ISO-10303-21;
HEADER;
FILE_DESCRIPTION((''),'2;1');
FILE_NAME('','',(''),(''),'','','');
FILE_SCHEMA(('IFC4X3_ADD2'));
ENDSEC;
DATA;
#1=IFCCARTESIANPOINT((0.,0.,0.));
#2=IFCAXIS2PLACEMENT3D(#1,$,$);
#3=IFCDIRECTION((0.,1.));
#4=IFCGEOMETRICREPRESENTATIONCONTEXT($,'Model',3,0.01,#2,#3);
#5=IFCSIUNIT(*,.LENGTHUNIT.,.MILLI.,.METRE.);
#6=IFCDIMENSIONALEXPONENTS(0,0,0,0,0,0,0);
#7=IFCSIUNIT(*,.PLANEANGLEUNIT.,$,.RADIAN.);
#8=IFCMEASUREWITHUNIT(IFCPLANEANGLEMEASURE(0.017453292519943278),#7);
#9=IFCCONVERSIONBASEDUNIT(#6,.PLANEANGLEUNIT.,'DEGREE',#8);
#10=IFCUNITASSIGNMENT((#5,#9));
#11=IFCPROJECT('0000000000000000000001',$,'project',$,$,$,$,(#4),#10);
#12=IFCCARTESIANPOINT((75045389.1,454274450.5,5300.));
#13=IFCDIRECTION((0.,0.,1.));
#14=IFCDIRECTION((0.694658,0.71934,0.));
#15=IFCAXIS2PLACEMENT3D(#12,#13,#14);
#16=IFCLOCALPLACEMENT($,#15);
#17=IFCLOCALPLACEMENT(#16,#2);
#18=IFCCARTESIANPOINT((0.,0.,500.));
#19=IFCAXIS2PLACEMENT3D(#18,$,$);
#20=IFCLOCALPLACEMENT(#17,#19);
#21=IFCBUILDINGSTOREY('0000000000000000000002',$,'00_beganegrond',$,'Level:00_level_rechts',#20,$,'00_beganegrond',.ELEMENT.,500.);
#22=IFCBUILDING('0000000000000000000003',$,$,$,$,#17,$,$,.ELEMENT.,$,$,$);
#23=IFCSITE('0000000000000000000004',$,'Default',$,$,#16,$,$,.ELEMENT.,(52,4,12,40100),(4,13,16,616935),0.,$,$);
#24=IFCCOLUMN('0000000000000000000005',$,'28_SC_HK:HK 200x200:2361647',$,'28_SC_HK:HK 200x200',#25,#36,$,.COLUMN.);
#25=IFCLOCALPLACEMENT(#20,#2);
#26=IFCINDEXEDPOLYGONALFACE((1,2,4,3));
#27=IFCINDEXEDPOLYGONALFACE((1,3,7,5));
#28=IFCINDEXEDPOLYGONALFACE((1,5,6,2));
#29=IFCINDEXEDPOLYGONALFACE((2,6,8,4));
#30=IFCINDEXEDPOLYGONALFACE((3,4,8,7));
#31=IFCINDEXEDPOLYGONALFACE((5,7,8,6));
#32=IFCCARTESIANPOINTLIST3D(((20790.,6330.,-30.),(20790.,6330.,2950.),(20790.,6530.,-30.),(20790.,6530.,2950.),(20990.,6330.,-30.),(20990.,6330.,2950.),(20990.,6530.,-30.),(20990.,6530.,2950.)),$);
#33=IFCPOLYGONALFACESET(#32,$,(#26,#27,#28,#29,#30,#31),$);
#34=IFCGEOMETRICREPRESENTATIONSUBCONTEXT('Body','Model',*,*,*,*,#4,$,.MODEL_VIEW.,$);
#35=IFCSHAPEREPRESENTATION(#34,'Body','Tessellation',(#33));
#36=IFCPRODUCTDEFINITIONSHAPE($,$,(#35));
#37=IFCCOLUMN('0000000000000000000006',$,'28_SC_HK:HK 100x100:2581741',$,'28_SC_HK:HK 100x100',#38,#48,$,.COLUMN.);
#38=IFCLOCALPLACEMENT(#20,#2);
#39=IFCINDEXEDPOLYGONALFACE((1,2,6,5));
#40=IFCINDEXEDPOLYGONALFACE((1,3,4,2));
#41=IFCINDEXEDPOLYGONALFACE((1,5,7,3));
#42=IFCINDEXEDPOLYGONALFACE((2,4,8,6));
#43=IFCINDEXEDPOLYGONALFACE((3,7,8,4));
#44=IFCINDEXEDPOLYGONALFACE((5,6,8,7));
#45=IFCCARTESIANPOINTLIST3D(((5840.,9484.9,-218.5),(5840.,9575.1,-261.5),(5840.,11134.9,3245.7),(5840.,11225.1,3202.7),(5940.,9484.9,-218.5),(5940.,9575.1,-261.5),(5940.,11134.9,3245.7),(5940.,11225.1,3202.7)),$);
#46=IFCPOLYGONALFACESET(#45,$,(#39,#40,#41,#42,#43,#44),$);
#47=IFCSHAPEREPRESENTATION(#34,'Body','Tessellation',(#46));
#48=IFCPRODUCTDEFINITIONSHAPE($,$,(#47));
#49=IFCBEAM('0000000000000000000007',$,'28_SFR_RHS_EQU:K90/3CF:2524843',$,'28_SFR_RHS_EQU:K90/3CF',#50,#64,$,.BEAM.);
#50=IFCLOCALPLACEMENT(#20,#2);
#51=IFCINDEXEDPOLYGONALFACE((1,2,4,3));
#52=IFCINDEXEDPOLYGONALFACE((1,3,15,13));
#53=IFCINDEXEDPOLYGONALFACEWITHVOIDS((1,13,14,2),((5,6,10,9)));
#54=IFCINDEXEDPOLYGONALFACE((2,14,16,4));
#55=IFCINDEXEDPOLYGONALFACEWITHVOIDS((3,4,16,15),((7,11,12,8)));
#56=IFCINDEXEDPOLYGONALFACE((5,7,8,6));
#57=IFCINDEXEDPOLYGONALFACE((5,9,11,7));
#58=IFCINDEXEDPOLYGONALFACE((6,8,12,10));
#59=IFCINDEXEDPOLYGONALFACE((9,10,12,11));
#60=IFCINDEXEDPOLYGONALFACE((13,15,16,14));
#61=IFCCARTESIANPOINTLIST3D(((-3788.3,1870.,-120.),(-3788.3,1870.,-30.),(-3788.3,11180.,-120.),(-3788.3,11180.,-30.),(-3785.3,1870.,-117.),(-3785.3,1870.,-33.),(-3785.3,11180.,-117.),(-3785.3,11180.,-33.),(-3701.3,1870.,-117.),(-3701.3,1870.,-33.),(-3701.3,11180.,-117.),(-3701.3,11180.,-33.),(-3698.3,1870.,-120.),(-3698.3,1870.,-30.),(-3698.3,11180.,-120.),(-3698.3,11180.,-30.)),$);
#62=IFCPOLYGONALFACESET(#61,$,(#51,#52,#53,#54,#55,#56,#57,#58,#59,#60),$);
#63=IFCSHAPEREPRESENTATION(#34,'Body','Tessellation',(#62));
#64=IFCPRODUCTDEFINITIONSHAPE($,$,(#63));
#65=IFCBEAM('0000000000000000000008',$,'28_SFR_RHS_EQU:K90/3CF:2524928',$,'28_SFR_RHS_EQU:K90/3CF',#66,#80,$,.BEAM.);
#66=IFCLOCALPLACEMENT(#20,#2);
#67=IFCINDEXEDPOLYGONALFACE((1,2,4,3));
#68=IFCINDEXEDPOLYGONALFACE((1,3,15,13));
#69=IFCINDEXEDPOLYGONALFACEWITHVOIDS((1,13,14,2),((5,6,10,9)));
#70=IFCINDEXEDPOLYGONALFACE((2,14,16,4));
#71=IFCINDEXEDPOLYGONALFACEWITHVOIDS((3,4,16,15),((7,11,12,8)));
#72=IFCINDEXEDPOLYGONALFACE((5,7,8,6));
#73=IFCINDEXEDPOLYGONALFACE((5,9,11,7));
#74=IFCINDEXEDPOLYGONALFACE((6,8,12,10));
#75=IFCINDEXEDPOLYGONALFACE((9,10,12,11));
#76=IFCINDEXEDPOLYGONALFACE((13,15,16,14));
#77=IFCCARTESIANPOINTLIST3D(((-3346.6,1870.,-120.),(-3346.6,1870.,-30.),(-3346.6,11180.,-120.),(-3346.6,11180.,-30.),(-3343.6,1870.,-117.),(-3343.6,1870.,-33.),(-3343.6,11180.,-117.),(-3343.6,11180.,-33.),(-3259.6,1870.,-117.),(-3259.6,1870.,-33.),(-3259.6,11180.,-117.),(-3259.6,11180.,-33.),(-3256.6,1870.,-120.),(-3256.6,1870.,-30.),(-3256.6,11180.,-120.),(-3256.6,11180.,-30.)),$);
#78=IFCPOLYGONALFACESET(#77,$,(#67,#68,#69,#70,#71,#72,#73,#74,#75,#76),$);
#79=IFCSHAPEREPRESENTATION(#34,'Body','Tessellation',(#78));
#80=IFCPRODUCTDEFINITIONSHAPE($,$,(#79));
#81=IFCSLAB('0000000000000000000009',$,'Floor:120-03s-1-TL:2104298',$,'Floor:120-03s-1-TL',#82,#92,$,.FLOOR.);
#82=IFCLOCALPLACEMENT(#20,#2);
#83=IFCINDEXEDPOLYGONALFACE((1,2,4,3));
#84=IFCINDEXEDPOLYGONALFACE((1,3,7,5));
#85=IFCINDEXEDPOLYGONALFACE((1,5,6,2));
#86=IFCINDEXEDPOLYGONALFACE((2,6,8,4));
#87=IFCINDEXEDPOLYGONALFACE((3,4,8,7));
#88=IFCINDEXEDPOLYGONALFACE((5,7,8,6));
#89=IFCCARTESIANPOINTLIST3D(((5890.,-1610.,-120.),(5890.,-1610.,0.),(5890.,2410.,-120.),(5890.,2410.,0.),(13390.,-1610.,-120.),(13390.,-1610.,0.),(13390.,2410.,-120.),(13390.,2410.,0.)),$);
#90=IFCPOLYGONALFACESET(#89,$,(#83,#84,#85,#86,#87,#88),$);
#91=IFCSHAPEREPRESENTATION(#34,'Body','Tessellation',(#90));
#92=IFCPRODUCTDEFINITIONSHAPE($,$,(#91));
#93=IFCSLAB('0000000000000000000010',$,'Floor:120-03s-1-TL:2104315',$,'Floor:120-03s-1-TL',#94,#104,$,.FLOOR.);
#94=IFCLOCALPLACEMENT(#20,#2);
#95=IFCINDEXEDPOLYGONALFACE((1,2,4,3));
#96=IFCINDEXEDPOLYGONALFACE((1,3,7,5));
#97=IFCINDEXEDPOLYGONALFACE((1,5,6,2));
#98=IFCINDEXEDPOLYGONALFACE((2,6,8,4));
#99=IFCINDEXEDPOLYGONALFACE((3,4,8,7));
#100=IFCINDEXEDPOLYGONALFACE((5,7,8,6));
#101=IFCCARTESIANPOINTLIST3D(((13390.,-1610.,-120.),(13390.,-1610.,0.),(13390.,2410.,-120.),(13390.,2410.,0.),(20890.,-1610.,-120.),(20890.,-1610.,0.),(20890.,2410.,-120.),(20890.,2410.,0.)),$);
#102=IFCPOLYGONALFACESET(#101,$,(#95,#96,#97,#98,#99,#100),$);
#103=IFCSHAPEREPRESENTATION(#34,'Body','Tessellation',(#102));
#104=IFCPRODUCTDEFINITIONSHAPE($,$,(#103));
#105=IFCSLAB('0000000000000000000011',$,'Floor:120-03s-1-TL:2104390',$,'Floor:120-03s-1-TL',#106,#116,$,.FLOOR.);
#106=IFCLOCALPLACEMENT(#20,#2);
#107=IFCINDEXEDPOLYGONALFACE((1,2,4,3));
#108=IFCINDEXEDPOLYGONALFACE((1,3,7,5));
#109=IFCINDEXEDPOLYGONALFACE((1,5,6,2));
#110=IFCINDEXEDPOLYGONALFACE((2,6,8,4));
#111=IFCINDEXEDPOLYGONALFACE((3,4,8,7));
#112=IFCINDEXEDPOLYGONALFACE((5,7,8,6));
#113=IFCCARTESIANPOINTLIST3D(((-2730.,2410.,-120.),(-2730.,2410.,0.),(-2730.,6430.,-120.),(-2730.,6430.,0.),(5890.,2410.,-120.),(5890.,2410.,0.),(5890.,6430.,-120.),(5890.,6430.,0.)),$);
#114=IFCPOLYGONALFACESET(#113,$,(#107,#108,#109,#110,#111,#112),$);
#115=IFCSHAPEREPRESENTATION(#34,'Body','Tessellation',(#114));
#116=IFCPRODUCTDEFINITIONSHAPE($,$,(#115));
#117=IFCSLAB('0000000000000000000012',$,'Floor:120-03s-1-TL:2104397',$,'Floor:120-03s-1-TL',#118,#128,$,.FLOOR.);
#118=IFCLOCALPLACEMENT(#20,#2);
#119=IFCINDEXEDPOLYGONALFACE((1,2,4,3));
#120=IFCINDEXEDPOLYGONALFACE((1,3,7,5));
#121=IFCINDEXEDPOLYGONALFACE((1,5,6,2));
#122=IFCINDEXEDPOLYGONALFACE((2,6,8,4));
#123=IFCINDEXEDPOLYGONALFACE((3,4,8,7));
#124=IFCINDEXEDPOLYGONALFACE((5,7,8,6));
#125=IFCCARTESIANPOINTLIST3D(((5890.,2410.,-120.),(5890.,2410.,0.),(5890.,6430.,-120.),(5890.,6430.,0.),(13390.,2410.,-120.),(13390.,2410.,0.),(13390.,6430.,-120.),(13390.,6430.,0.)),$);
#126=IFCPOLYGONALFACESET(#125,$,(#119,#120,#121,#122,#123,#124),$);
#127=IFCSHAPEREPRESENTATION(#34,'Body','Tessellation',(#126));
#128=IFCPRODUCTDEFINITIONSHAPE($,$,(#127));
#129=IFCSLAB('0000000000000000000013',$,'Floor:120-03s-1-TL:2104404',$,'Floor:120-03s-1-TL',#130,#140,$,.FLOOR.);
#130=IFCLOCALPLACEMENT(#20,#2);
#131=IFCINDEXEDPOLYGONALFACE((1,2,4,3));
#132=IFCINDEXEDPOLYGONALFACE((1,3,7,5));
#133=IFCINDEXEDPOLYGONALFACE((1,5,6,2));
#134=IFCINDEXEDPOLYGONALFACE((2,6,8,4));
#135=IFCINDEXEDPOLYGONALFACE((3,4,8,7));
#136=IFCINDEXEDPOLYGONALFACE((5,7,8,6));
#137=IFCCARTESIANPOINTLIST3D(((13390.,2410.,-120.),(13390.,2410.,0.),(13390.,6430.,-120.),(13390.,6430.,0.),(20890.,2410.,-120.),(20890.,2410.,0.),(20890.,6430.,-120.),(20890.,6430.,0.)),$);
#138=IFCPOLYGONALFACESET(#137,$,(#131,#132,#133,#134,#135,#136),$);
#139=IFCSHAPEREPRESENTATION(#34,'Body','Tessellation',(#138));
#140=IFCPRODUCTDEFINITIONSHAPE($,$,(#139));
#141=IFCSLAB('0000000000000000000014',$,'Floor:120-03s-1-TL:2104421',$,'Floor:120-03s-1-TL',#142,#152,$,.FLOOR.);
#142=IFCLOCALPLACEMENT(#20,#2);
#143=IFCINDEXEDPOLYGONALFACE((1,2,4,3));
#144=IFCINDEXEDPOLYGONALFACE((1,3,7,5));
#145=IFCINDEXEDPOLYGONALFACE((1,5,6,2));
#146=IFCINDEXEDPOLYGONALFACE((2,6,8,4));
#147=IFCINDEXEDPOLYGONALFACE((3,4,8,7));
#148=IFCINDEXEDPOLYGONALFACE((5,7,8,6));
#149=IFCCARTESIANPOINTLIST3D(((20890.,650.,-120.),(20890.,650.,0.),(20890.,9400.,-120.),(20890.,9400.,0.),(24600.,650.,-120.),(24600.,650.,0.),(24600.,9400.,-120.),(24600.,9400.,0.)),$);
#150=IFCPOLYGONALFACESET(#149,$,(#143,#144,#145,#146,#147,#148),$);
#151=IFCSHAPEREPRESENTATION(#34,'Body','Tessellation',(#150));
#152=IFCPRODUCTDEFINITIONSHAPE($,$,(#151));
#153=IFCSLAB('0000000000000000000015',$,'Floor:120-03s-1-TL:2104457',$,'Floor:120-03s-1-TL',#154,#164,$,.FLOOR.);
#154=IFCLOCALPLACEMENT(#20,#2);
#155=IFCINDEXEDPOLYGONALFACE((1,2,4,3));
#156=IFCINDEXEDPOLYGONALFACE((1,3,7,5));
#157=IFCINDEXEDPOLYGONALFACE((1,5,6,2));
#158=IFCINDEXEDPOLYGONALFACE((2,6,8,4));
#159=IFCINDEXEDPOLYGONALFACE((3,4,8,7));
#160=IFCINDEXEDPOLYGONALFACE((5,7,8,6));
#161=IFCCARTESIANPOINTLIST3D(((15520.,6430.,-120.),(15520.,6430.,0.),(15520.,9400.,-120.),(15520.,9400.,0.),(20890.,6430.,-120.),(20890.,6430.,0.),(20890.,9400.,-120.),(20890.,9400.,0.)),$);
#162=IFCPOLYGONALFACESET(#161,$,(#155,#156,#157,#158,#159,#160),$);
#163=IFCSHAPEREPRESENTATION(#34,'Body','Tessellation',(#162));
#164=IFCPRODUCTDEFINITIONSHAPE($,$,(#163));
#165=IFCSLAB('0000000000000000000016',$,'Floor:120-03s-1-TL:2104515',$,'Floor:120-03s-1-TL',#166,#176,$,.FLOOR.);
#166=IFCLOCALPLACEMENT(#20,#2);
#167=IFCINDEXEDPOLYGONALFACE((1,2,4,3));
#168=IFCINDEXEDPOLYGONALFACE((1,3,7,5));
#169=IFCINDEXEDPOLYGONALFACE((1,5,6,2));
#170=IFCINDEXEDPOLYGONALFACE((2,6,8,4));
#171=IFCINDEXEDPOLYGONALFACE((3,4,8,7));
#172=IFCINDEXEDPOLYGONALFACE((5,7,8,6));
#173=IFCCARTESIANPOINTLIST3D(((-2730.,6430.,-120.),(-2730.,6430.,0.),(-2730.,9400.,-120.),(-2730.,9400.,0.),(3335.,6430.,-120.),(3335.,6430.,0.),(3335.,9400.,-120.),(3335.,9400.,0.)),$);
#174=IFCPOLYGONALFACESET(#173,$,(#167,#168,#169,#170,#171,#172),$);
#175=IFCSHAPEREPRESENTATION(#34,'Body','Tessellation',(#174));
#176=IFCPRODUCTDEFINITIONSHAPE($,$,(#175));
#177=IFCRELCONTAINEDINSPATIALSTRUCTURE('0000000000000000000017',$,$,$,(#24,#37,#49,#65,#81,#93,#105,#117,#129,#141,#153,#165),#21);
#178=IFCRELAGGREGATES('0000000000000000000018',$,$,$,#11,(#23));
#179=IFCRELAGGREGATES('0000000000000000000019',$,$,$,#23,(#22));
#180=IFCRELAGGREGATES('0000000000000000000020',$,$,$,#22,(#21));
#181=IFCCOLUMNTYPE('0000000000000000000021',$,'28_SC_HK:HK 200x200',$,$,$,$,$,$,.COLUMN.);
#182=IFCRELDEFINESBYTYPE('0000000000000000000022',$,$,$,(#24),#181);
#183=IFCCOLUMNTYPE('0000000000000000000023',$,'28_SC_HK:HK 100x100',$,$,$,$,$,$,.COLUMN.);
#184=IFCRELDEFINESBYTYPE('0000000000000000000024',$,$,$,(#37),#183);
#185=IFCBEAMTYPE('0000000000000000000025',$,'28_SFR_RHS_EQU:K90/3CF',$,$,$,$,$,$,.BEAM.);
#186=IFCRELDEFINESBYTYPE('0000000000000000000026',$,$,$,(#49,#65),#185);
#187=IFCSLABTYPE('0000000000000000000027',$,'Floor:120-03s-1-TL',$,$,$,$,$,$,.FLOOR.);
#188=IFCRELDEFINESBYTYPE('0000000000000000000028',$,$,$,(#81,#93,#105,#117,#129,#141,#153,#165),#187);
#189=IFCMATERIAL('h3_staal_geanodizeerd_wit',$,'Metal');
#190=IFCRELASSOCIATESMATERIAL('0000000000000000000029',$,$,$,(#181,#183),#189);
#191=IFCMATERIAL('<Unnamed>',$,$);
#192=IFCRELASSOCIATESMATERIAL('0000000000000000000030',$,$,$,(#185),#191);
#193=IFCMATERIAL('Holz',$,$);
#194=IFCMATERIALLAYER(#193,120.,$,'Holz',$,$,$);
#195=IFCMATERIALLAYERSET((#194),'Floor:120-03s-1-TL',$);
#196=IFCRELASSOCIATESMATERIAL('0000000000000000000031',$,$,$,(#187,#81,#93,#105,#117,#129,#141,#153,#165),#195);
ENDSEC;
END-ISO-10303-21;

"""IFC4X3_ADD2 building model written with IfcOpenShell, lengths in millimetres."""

from ifc_helpers import new_model, entity, si_unit, converted_unit, direction, frame, frame_2d, origin, origin_2d_with_axis, place, context, subcontext, project, spatial, polyline, rectangle, outline, extrude, source, transform, mapped, material, layer, layer_set, layer_usage, material_profile, profile_set, type_object, type_shapes, element, save


model = new_model("IFC4X3_ADD2")

# Units and contexts
model_context = context("Model", 3, precision=0.01, world=origin(), true_north=direction((0.0, 1.0)))
body_context = subcontext(model_context, "Body", "Model", "MODEL_VIEW")
ifc_project = project(units=[si_unit("LENGTHUNIT", "METRE", prefix="MILLI"), converted_unit("PLANEANGLEUNIT", "DEGREE", entity("IfcPlaneAngleMeasure", 0.017453292519943278), si_unit("PLANEANGLEUNIT", "RADIAN"), dimensions=[0, 0, 0, 0, 0, 0, 0])], contexts=[model_context])

# Site, building, storey
site_placement = place(None, frame((75045389.1, 454274450.5, 5300.0), z_axis=(0.0, 0.0, 1.0), x_axis=(0.694658, 0.71934, 0.0)))
site = spatial("IfcSite", under=ifc_project, at=site_placement, Name="Default", CompositionType="ELEMENT", RefLatitude=(52, 4, 12, 40100), RefLongitude=(4, 13, 16, 616935), RefElevation=0.0)
building_placement = place(site_placement, origin())
building = spatial("IfcBuilding", under=site, at=building_placement, CompositionType="ELEMENT")
storey_placement = place(building_placement, frame((0.0, 0.0, 500.0)))
storey = spatial("IfcBuildingStorey", under=building, at=storey_placement, Name="00_beganegrond", ObjectType="Level:00_level_rechts", LongName="00_beganegrond", CompositionType="ELEMENT", Elevation=500.0)

# Columns
ifc_material_1 = material(Name="h3_staal_geanodizeerd_wit", Category="Metal")
ifc_material_profile_1 = material_profile(ifc_material_1, rectangle(XDim=200.0, YDim=200.0, at=origin_2d_with_axis()), Name="HK 200x200")
ifc_profile_set_1 = profile_set([ifc_material_profile_1], Name="HK 200x200")
column_type_1 = type_object("IfcColumnType", Name="28_SC_HK:HK 200x200", PredefinedType="COLUMN", material=ifc_profile_set_1)
shared_shape_1 = source(origin(), body_context, "Body", "SweptSolid", [
    extrude(rectangle(XDim=200.0, YDim=200.0, at=origin_2d_with_axis()), frame((20890.0, 6430.0, 470.0), z_axis=(0.0, 0.0, 1.0), x_axis=(-1.0, 0.0, 0.0)), (0.0, 0.0, 1.0), 2980.0),
])
type_shapes(column_type_1, [shared_shape_1])
column_1_placement = place(storey_placement, frame((0.0, 0.0, -500.0)))
element("IfcColumn", 1, at=column_1_placement, inside=storey, type_object=column_type_1, Name="28_SC_HK:HK 200x200:2361647", ObjectType="28_SC_HK:HK 200x200", PredefinedType="COLUMN", context=body_context, shape_type="MappedRepresentation", body=[
    mapped(shared_shape_1, transform((0.0, 0.0, 0.0), scale=1.0)),
])
ifc_material_profile_2 = material_profile(ifc_material_1, rectangle(XDim=100.0, YDim=100.0, at=frame_2d((0.0, 0.0), x_axis=(1.0, 0.0))), Name="HK 100x100")
ifc_profile_set_2 = profile_set([ifc_material_profile_2], Name="HK 100x100")
column_type_2 = type_object("IfcColumnType", Name="28_SC_HK:HK 100x100", PredefinedType="COLUMN", material=ifc_profile_set_2)
shared_shape_2 = source(origin(), body_context, "Body", "SweptSolid", [
    extrude(rectangle(XDim=100.0, YDim=100.0, at=frame_2d((0.0, 0.0), x_axis=(1.0, 0.0))), frame((5890.0, 9530.0, 260.0), z_axis=(0.0, 0.430013, 0.902823), x_axis=(0.0, -0.902823, 0.430013)), (0.0, 0.0, 1.0), 3837.1),
])
type_shapes(column_type_2, [shared_shape_2])
column_2_placement = place(storey_placement, frame((0.0, 0.0, -500.0)))
element("IfcColumn", 2, at=column_2_placement, inside=storey, type_object=column_type_2, Name="28_SC_HK:HK 100x100:2581741", ObjectType="28_SC_HK:HK 100x100", PredefinedType="COLUMN", context=body_context, shape_type="MappedRepresentation", body=[
    mapped(shared_shape_2, transform((0.0, 0.0, 0.0), scale=1.0)),
])

# Beams
ifc_material_2 = material(Name="<Unnamed>")
ifc_material_profile_3 = material_profile(ifc_material_2, outline(polyline([(-45.0, -45.0), (45.0, -45.0), (45.0, 45.0), (-45.0, 45.0), (-45.0, -45.0)]), holes=[polyline([(42.0, -42.0), (-42.0, -42.0), (-42.0, 42.0), (42.0, 42.0), (42.0, -42.0)])]), Name="K90/3CF")
ifc_profile_set_3 = profile_set([ifc_material_profile_3], Name="K90/3CF")
beam_type = type_object("IfcBeamType", Name="28_SFR_RHS_EQU:K90/3CF", PredefinedType="BEAM", material=ifc_profile_set_3)
shared_shape_3 = source(origin(), body_context, "Body", "SweptSolid", [
    extrude(outline(polyline([(-45.0, -45.0), (45.0, -45.0), (45.0, 45.0), (-45.0, 45.0), (-45.0, -45.0)]), holes=[polyline([(42.0, -42.0), (-42.0, -42.0), (-42.0, 42.0), (42.0, 42.0), (42.0, -42.0)])]), frame((-4655.0, 0.0, 0.0), z_axis=(1.0, 0.0, 0.0), x_axis=(0.0, -1.0, 0.0)), (0.0, 0.0, 1.0), 9310.0),
])
type_shapes(beam_type, [shared_shape_3])
for number, where, z_axis, x_axis, name in (
    (3, (-3743.3, 6525.0, -75.0), (0.0, 0.0, 1.0), (0.0, 1.0, 0.0), "28_SFR_RHS_EQU:K90/3CF:2524843"),
    (4, (-3301.6, 6525.0, -75.0), (0.0, 0.0, 1.0), (0.0, 1.0, 0.0), "28_SFR_RHS_EQU:K90/3CF:2524928"),
):
    element("IfcBeam", number, at=place(storey_placement, frame(where, z_axis=z_axis, x_axis=x_axis)), inside=storey, type_object=beam_type, Name=name, ObjectType="28_SFR_RHS_EQU:K90/3CF", PredefinedType="BEAM", context=body_context, shape_type="MappedRepresentation", body=[
        mapped(shared_shape_3, transform((0.0, 0.0, 0.0), scale=1.0)),
    ])

# Slabs
ifc_material_3 = material(Name="Holz")
ifc_layer_1 = layer(ifc_material_3, 120.0, Name="Holz")
ifc_layer_set_1 = layer_set([ifc_layer_1], Name="Floor:120-03s-1-TL")
slab_type_1 = type_object("IfcSlabType", Name="Floor:120-03s-1-TL", PredefinedType="FLOOR", material=ifc_layer_set_1)
ifc_layer_usage_1 = layer_usage(ifc_layer_set_1, "AXIS3", "POSITIVE", 0.0)
slab_1_placement = place(storey_placement, origin())
element("IfcSlab", 5, at=slab_1_placement, inside=storey, type_object=slab_type_1, material=ifc_layer_usage_1, Name="Floor:120-03s-1-TL:2104298", ObjectType="Floor:120-03s-1-TL", PredefinedType="FLOOR", context=body_context, shape_type="SweptSolid", body=[
    extrude(rectangle(XDim=4020.0, YDim=7500.0, at=origin_2d_with_axis()), frame((9640.0, 400.0, 0.0), z_axis=(0.0, 0.0, -1.0), x_axis=(0.0, 1.0, 0.0)), (0.0, 0.0, 1.0), 120.0),
])
ifc_layer_usage_2 = layer_usage(ifc_layer_set_1, "AXIS3", "POSITIVE", 0.0)
slab_2_placement = place(storey_placement, origin())
element("IfcSlab", 6, at=slab_2_placement, inside=storey, type_object=slab_type_1, material=ifc_layer_usage_2, Name="Floor:120-03s-1-TL:2104315", ObjectType="Floor:120-03s-1-TL", PredefinedType="FLOOR", context=body_context, shape_type="SweptSolid", body=[
    extrude(rectangle(XDim=4020.0, YDim=7500.0, at=origin_2d_with_axis()), frame((17140.0, 400.0, 0.0), z_axis=(0.0, 0.0, -1.0), x_axis=(0.0, 1.0, 0.0)), (0.0, 0.0, 1.0), 120.0),
])
ifc_layer_usage_3 = layer_usage(ifc_layer_set_1, "AXIS3", "POSITIVE", 0.0)
slab_3_placement = place(storey_placement, origin())
element("IfcSlab", 7, at=slab_3_placement, inside=storey, type_object=slab_type_1, material=ifc_layer_usage_3, Name="Floor:120-03s-1-TL:2104390", ObjectType="Floor:120-03s-1-TL", PredefinedType="FLOOR", context=body_context, shape_type="SweptSolid", body=[
    extrude(rectangle(XDim=4020.0, YDim=8620.0, at=frame_2d((0.0, 0.0), x_axis=(1.0, 0.0))), frame((1580.0, 4420.0, 0.0), z_axis=(0.0, 0.0, -1.0), x_axis=(0.0, 1.0, 0.0)), (0.0, 0.0, 1.0), 120.0),
])
ifc_layer_usage_4 = layer_usage(ifc_layer_set_1, "AXIS3", "POSITIVE", 0.0)
slab_4_placement = place(storey_placement, origin())
element("IfcSlab", 8, at=slab_4_placement, inside=storey, type_object=slab_type_1, material=ifc_layer_usage_4, Name="Floor:120-03s-1-TL:2104397", ObjectType="Floor:120-03s-1-TL", PredefinedType="FLOOR", context=body_context, shape_type="SweptSolid", body=[
    extrude(rectangle(XDim=4020.0, YDim=7500.0, at=origin_2d_with_axis()), frame((9640.0, 4420.0, 0.0), z_axis=(0.0, 0.0, -1.0), x_axis=(0.0, 1.0, 0.0)), (0.0, 0.0, 1.0), 120.0),
])
ifc_layer_usage_5 = layer_usage(ifc_layer_set_1, "AXIS3", "POSITIVE", 0.0)
slab_5_placement = place(storey_placement, origin())
element("IfcSlab", 9, at=slab_5_placement, inside=storey, type_object=slab_type_1, material=ifc_layer_usage_5, Name="Floor:120-03s-1-TL:2104404", ObjectType="Floor:120-03s-1-TL", PredefinedType="FLOOR", context=body_context, shape_type="SweptSolid", body=[
    extrude(rectangle(XDim=4020.0, YDim=7500.0, at=frame_2d((0.0, 0.0), x_axis=(1.0, 0.0))), frame((17140.0, 4420.0, 0.0), z_axis=(0.0, 0.0, -1.0), x_axis=(0.0, 1.0, 0.0)), (0.0, 0.0, 1.0), 120.0),
])
ifc_layer_usage_6 = layer_usage(ifc_layer_set_1, "AXIS3", "POSITIVE", 0.0)
slab_6_placement = place(storey_placement, origin())
element("IfcSlab", 10, at=slab_6_placement, inside=storey, type_object=slab_type_1, material=ifc_layer_usage_6, Name="Floor:120-03s-1-TL:2104421", ObjectType="Floor:120-03s-1-TL", PredefinedType="FLOOR", context=body_context, shape_type="SweptSolid", body=[
    extrude(rectangle(XDim=8750.0, YDim=3710.0, at=frame_2d((0.0, 0.0), x_axis=(1.0, 0.0))), frame((22745.0, 5025.0, 0.0), z_axis=(0.0, 0.0, -1.0), x_axis=(0.0, 1.0, 0.0)), (0.0, 0.0, 1.0), 120.0),
])
ifc_layer_usage_7 = layer_usage(ifc_layer_set_1, "AXIS3", "POSITIVE", 0.0)
slab_7_placement = place(storey_placement, origin())
element("IfcSlab", 11, at=slab_7_placement, inside=storey, type_object=slab_type_1, material=ifc_layer_usage_7, Name="Floor:120-03s-1-TL:2104457", ObjectType="Floor:120-03s-1-TL", PredefinedType="FLOOR", context=body_context, shape_type="SweptSolid", body=[
    extrude(rectangle(XDim=2970.0, YDim=5370.0, at=origin_2d_with_axis()), frame((18205.0, 7915.0, 0.0), z_axis=(0.0, 0.0, -1.0), x_axis=(0.0, 1.0, 0.0)), (0.0, 0.0, 1.0), 120.0),
])
ifc_layer_usage_8 = layer_usage(ifc_layer_set_1, "AXIS3", "POSITIVE", 0.0)
slab_8_placement = place(storey_placement, origin())
element("IfcSlab", 12, at=slab_8_placement, inside=storey, type_object=slab_type_1, material=ifc_layer_usage_8, Name="Floor:120-03s-1-TL:2104515", ObjectType="Floor:120-03s-1-TL", PredefinedType="FLOOR", context=body_context, shape_type="SweptSolid", body=[
    extrude(rectangle(XDim=2970.0, YDim=6065.0, at=frame_2d((0.0, 0.0), x_axis=(1.0, 0.0))), frame((302.5, 7915.0, 0.0), z_axis=(0.0, 0.0, -1.0), x_axis=(0.0, 1.0, 0.0)), (0.0, 0.0, 1.0), 120.0),
])

save(model, "model.ifc")
